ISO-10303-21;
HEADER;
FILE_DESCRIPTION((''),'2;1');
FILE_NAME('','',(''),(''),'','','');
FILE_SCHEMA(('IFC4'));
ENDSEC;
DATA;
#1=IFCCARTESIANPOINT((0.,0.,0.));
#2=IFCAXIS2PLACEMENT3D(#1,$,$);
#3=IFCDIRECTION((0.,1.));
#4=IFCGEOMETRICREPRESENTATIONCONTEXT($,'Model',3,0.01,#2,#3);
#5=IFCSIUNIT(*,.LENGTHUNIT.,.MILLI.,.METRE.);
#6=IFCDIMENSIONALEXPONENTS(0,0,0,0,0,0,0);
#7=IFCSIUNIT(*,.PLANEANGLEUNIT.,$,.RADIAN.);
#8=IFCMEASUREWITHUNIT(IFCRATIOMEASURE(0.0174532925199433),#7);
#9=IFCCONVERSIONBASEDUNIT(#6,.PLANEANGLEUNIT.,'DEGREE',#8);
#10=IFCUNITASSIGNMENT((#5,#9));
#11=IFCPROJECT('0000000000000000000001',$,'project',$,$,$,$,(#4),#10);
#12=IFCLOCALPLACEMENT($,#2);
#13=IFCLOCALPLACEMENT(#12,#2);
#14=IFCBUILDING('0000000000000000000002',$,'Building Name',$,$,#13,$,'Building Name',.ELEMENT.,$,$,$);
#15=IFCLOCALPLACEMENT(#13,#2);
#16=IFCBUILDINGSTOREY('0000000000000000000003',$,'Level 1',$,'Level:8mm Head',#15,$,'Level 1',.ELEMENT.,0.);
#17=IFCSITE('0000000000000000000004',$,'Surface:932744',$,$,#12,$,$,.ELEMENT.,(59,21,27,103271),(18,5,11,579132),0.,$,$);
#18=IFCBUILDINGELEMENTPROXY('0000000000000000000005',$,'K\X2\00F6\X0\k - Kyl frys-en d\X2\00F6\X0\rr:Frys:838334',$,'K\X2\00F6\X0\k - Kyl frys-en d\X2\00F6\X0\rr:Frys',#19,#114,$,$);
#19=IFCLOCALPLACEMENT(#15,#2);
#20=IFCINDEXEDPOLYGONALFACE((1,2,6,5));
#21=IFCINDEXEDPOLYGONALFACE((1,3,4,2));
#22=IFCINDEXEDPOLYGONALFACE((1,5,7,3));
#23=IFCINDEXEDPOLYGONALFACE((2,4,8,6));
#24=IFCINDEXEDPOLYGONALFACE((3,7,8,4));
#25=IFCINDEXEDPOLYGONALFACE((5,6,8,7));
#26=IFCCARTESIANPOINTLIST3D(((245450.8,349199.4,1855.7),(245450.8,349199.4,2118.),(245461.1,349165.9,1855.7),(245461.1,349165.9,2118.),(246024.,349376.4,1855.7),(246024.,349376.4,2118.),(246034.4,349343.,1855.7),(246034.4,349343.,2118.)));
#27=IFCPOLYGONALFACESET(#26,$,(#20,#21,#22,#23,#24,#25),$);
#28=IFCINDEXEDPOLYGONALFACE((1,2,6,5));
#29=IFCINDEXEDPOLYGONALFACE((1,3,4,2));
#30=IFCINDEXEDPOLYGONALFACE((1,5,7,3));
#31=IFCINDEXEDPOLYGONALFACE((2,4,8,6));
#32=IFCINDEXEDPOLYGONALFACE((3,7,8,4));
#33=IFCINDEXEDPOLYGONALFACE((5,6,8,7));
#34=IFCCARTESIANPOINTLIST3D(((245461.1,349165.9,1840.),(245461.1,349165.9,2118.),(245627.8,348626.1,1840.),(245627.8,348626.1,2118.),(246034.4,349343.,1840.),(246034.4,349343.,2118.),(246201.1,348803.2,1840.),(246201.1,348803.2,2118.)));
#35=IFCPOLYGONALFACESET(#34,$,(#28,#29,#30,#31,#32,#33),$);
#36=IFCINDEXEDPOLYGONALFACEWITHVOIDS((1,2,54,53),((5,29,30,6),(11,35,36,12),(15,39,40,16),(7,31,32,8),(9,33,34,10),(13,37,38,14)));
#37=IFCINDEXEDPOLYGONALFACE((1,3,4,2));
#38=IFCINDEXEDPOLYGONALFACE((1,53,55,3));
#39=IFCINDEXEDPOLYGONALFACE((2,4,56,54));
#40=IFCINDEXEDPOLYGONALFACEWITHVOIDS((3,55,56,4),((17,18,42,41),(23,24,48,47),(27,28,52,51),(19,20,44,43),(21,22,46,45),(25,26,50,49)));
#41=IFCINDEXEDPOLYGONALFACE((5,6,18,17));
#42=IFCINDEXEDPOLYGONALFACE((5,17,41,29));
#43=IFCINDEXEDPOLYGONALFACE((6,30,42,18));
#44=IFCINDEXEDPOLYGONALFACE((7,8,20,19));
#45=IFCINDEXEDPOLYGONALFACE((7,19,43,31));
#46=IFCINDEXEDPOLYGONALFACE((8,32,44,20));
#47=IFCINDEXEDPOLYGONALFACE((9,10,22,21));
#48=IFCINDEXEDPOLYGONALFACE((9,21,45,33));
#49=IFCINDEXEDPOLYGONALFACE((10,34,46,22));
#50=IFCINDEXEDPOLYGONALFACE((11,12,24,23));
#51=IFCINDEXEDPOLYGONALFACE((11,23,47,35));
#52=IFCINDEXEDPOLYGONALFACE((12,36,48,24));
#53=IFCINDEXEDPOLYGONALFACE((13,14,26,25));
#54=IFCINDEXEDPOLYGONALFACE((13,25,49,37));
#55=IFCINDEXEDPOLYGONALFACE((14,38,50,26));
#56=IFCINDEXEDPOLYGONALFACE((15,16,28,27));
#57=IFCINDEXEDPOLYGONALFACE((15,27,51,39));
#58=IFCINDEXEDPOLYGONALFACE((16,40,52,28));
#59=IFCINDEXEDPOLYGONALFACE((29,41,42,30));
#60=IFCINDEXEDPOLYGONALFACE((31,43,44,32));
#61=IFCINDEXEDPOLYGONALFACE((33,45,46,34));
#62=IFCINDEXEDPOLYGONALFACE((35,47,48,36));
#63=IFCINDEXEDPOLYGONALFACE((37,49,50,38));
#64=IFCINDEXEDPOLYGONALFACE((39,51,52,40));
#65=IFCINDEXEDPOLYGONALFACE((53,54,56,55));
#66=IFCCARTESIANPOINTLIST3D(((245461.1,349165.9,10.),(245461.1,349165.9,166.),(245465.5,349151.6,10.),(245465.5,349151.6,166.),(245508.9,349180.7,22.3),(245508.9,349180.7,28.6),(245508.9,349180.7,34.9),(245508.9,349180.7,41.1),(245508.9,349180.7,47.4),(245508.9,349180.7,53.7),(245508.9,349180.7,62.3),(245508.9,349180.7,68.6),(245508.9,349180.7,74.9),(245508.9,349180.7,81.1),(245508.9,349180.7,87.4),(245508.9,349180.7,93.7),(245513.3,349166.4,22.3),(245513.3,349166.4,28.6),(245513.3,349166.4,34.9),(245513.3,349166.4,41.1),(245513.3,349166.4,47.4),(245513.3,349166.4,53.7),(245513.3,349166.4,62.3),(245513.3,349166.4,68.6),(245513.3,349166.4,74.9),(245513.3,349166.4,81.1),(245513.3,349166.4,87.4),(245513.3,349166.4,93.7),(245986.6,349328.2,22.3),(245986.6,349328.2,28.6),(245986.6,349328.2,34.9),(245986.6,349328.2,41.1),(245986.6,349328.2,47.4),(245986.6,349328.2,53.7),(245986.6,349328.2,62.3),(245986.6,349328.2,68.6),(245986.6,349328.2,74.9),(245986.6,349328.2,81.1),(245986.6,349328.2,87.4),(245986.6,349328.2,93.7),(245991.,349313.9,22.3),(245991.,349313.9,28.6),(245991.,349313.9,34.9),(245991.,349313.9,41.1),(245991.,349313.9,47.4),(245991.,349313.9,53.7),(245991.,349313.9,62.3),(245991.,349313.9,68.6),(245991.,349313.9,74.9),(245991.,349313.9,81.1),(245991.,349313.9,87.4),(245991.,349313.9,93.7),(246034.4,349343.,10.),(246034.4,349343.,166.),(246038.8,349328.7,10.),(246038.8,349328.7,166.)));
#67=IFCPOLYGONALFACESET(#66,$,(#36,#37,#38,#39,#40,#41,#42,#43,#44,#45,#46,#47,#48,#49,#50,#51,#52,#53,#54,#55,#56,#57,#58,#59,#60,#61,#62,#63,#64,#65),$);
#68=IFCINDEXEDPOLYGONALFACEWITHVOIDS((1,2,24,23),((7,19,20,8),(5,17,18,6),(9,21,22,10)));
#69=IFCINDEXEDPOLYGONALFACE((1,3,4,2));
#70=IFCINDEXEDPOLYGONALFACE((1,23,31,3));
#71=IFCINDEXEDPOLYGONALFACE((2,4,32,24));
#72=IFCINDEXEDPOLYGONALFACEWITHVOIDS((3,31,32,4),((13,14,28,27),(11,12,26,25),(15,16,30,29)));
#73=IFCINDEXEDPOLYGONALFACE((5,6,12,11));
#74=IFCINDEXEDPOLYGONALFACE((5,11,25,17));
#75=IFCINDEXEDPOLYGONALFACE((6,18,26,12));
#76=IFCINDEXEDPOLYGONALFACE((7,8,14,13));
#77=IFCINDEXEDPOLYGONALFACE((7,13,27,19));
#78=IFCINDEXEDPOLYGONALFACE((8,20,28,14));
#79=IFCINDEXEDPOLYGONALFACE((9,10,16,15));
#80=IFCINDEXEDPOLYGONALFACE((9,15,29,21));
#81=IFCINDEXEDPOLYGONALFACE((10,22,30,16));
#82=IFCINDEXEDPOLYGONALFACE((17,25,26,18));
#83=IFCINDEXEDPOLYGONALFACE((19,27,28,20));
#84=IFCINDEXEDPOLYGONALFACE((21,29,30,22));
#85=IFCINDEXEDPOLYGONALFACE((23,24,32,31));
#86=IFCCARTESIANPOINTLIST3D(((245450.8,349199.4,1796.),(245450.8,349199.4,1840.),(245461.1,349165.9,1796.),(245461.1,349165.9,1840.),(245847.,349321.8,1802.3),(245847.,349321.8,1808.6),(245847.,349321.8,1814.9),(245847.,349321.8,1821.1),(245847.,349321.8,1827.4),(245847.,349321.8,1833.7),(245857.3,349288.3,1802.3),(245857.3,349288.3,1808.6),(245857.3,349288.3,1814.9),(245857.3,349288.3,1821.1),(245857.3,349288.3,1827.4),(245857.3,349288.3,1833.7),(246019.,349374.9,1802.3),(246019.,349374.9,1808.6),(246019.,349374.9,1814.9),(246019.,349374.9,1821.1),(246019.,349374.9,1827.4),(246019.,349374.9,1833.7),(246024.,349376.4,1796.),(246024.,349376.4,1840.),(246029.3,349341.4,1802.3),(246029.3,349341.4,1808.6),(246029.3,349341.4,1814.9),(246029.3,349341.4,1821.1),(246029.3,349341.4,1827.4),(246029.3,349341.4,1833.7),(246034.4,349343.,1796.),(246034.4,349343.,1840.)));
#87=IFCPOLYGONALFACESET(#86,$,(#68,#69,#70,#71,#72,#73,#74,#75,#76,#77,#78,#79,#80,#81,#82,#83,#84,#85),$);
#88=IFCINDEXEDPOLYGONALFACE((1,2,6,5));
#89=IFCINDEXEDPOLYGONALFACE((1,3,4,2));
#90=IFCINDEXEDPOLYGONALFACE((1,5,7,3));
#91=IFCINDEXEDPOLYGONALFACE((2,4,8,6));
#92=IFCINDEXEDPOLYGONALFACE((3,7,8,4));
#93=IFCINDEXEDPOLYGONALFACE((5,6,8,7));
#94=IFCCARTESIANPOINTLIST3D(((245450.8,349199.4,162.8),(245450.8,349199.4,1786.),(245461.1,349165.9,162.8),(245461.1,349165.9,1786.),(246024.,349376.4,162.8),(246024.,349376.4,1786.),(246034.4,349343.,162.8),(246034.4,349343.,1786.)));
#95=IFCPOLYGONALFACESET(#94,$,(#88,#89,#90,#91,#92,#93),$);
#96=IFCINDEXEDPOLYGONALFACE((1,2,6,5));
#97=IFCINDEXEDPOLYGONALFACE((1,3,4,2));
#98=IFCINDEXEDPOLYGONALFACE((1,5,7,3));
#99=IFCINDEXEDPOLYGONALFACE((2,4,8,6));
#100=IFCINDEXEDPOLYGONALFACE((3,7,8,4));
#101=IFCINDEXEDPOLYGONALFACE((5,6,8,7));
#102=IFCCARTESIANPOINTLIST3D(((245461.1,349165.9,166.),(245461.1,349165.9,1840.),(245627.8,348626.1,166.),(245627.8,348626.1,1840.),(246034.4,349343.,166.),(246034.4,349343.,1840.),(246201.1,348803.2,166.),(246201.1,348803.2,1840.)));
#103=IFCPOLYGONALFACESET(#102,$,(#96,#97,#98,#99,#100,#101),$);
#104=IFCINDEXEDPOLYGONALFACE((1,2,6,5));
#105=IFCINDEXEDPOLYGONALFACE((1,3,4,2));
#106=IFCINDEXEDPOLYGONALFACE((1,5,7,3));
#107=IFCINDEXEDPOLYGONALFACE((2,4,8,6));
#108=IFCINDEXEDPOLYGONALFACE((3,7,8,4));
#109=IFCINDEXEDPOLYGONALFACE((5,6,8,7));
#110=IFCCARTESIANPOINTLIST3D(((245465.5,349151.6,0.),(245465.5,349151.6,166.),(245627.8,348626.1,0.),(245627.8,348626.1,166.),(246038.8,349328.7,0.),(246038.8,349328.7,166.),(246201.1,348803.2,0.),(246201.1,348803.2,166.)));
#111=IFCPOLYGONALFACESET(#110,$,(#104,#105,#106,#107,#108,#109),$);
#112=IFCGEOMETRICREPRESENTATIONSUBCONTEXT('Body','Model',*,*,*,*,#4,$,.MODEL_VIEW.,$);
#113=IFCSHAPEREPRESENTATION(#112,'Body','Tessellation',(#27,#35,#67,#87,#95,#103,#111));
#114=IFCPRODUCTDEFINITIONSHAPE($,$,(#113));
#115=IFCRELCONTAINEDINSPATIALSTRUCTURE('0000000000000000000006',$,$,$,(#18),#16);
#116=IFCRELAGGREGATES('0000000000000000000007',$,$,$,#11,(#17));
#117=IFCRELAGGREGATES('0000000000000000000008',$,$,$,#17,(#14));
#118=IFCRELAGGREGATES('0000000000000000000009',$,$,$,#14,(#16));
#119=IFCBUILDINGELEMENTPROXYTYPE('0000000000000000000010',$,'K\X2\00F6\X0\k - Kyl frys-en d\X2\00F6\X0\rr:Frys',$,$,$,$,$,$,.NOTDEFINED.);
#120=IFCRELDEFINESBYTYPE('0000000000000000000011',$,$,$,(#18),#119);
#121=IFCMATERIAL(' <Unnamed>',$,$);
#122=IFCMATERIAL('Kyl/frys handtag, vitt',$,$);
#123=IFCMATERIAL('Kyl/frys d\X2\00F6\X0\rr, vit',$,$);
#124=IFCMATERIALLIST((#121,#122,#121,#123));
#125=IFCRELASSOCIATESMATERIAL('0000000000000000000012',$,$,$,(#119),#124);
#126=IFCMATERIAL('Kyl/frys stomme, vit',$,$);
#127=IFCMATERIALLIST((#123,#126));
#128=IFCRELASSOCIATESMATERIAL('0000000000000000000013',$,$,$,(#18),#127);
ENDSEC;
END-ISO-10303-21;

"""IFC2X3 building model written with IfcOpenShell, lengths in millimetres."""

from ifc_helpers import new_model, entity, si_unit, converted_unit, direction, frame, frame_2d, origin, origin_2d_with_axis, place, context, subcontext, project, spatial, polyline, rectangle, outline, extrude, source, transform, mapped, material, material_list, type_object, type_shapes, element, save


model = new_model("IFC2X3")

# Units and contexts
model_context = context("Model", 3, precision=0.01, world=origin(), true_north=direction((0.0, 1.0)))
body_context = subcontext(model_context, "Body", "Model", "MODEL_VIEW")
ifc_project = project(units=[si_unit("LENGTHUNIT", "METRE", prefix="MILLI"), converted_unit("PLANEANGLEUNIT", "DEGREE", entity("IfcRatioMeasure", 0.0174532925199433), si_unit("PLANEANGLEUNIT", "RADIAN"), dimensions=[0, 0, 0, 0, 0, 0, 0])], contexts=[model_context])

# Site, building, storey
site_placement = place(None, origin())
site = spatial("IfcSite", under=ifc_project, at=site_placement, Name="Surface:932744", CompositionType="ELEMENT", RefLatitude=(59, 21, 27, 103271), RefLongitude=(18, 5, 11, 579132), RefElevation=0.0)
building_placement = place(site_placement, origin())
building = spatial("IfcBuilding", under=site, at=building_placement, Name="Building Name", LongName="Building Name", CompositionType="ELEMENT")
storey_placement = place(building_placement, origin())
storey = spatial("IfcBuildingStorey", under=building, at=storey_placement, Name="Level 1", ObjectType="Level:8mm Head", LongName="Level 1", CompositionType="ELEMENT", Elevation=0.0)

# Building element proxy
ifc_material_1 = material(Name="Kyl/frys dörr, vit")
ifc_material_2 = material(Name="Kyl/frys stomme, vit")
ifc_material_list_1 = material_list([ifc_material_1, ifc_material_2])
ifc_material_3 = material(Name=" <Unnamed>")
ifc_material_4 = material(Name="Kyl/frys handtag, vitt")
ifc_material_list_2 = material_list([ifc_material_3, ifc_material_4, ifc_material_3, ifc_material_1])
building_element_proxy_type = type_object("IfcBuildingElementProxyType", Name="Kök - Kyl frys-en dörr:Frys", PredefinedType="NOTDEFINED", material=ifc_material_list_2)
shared_shape_1 = source(origin(), body_context, "Body", "SweptSolid", [
    extrude(rectangle(XDim=35.0, YDim=600.0, at=frame_2d((0.0, 0.0), x_axis=(1.0, 0.0))), frame((-254.6, 169.3, 1855.7), z_axis=(0.0, 0.0, 1.0), x_axis=(0.0, -1.0, 0.0)), (0.0, 0.0, 1.0), 262.3),
    extrude(rectangle(XDim=600.0, YDim=565.0, at=origin_2d_with_axis()), frame((-254.6, 469.3, 1840.0), z_axis=(0.0, 0.0, 1.0), x_axis=(-1.0, 0.0, 0.0)), (0.0, 0.0, 1.0), 278.0),
    extrude(outline(polyline([(-300.0, -78.0), (300.0, -78.0), (300.0, 78.0), (-300.0, 78.0), (-300.0, -78.0)]), holes=[polyline([(-250.0, 5.7), (250.0, 5.7), (250.0, -0.6), (-250.0, -0.6), (-250.0, 5.7)]), polyline([(-250.0, -6.9), (250.0, -6.9), (250.0, -13.1), (-250.0, -13.1), (-250.0, -6.9)]), polyline([(-250.0, -19.4), (250.0, -19.4), (250.0, -25.7), (-250.0, -25.7), (-250.0, -19.4)]), polyline([(-250.0, -34.3), (250.0, -34.3), (250.0, -40.6), (-250.0, -40.6), (-250.0, -34.3)]), polyline([(-250.0, -46.9), (250.0, -46.9), (250.0, -53.1), (-250.0, -53.1), (-250.0, -46.9)]), polyline([(-250.0, -59.4), (250.0, -59.4), (250.0, -65.7), (-250.0, -65.7), (-250.0, -59.4)])]), frame((-254.6, 186.8, 88.0), z_axis=(0.0, 1.0, 0.0), x_axis=(-1.0, 0.0, 0.0)), (0.0, 0.0, 1.0), 15.0),
    extrude(outline(polyline([(-300.0, -22.0), (300.0, -22.0), (300.0, 22.0), (-300.0, 22.0), (-300.0, -22.0)]), holes=[polyline([(114.7, 15.7), (294.7, 15.7), (294.7, 9.4), (114.7, 9.4), (114.7, 15.7)]), polyline([(114.7, 3.1), (294.7, 3.1), (294.7, -3.1), (114.7, -3.1), (114.7, 3.1)]), polyline([(114.7, -9.4), (294.7, -9.4), (294.7, -15.7), (114.7, -15.7), (114.7, -9.4)])]), frame((-254.6, 151.8, 1818.0), z_axis=(0.0, 1.0, 0.0), x_axis=(-1.0, 0.0, 0.0)), (0.0, 0.0, 1.0), 35.0),
    extrude(rectangle(XDim=35.0, YDim=600.0, at=frame_2d((0.0, 0.0), x_axis=(1.0, 0.0))), frame((-254.6, 169.3, 162.8), z_axis=(0.0, 0.0, 1.0), x_axis=(0.0, -1.0, 0.0)), (0.0, 0.0, 1.0), 1623.2),
    extrude(rectangle(XDim=600.0, YDim=565.0, at=frame_2d((0.0, 0.0), x_axis=(1.0, 0.0))), frame((-254.6, 469.3, 166.0), z_axis=(0.0, 0.0, 1.0), x_axis=(-1.0, 0.0, 0.0)), (0.0, 0.0, 1.0), 1674.0),
    extrude(rectangle(XDim=600.0, YDim=550.0, at=frame_2d((0.0, 0.0), x_axis=(1.0, 0.0))), frame((-254.6, 476.8, 0.0), z_axis=(0.0, 0.0, 1.0), x_axis=(-1.0, 0.0, 0.0)), (0.0, 0.0, 1.0), 166.0),
])
type_shapes(building_element_proxy_type, [shared_shape_1])
proxy_placement = place(storey_placement, frame((245449.3, 349357.8, 0.0), z_axis=(0.0, 0.0, 1.0), x_axis=(-0.955473, -0.29508, 0.0)))
element("IfcBuildingElementProxy", 1, at=proxy_placement, inside=storey, type_object=building_element_proxy_type, material=ifc_material_list_1, Name="Kök - Kyl frys-en dörr:Frys:838334", ObjectType="Kök - Kyl frys-en dörr:Frys", context=body_context, shape_type="MappedRepresentation", body=[
    mapped(shared_shape_1, transform((0.0, 0.0, 0.0), scale=1.0)),
])

save(model, "model.ifc")
